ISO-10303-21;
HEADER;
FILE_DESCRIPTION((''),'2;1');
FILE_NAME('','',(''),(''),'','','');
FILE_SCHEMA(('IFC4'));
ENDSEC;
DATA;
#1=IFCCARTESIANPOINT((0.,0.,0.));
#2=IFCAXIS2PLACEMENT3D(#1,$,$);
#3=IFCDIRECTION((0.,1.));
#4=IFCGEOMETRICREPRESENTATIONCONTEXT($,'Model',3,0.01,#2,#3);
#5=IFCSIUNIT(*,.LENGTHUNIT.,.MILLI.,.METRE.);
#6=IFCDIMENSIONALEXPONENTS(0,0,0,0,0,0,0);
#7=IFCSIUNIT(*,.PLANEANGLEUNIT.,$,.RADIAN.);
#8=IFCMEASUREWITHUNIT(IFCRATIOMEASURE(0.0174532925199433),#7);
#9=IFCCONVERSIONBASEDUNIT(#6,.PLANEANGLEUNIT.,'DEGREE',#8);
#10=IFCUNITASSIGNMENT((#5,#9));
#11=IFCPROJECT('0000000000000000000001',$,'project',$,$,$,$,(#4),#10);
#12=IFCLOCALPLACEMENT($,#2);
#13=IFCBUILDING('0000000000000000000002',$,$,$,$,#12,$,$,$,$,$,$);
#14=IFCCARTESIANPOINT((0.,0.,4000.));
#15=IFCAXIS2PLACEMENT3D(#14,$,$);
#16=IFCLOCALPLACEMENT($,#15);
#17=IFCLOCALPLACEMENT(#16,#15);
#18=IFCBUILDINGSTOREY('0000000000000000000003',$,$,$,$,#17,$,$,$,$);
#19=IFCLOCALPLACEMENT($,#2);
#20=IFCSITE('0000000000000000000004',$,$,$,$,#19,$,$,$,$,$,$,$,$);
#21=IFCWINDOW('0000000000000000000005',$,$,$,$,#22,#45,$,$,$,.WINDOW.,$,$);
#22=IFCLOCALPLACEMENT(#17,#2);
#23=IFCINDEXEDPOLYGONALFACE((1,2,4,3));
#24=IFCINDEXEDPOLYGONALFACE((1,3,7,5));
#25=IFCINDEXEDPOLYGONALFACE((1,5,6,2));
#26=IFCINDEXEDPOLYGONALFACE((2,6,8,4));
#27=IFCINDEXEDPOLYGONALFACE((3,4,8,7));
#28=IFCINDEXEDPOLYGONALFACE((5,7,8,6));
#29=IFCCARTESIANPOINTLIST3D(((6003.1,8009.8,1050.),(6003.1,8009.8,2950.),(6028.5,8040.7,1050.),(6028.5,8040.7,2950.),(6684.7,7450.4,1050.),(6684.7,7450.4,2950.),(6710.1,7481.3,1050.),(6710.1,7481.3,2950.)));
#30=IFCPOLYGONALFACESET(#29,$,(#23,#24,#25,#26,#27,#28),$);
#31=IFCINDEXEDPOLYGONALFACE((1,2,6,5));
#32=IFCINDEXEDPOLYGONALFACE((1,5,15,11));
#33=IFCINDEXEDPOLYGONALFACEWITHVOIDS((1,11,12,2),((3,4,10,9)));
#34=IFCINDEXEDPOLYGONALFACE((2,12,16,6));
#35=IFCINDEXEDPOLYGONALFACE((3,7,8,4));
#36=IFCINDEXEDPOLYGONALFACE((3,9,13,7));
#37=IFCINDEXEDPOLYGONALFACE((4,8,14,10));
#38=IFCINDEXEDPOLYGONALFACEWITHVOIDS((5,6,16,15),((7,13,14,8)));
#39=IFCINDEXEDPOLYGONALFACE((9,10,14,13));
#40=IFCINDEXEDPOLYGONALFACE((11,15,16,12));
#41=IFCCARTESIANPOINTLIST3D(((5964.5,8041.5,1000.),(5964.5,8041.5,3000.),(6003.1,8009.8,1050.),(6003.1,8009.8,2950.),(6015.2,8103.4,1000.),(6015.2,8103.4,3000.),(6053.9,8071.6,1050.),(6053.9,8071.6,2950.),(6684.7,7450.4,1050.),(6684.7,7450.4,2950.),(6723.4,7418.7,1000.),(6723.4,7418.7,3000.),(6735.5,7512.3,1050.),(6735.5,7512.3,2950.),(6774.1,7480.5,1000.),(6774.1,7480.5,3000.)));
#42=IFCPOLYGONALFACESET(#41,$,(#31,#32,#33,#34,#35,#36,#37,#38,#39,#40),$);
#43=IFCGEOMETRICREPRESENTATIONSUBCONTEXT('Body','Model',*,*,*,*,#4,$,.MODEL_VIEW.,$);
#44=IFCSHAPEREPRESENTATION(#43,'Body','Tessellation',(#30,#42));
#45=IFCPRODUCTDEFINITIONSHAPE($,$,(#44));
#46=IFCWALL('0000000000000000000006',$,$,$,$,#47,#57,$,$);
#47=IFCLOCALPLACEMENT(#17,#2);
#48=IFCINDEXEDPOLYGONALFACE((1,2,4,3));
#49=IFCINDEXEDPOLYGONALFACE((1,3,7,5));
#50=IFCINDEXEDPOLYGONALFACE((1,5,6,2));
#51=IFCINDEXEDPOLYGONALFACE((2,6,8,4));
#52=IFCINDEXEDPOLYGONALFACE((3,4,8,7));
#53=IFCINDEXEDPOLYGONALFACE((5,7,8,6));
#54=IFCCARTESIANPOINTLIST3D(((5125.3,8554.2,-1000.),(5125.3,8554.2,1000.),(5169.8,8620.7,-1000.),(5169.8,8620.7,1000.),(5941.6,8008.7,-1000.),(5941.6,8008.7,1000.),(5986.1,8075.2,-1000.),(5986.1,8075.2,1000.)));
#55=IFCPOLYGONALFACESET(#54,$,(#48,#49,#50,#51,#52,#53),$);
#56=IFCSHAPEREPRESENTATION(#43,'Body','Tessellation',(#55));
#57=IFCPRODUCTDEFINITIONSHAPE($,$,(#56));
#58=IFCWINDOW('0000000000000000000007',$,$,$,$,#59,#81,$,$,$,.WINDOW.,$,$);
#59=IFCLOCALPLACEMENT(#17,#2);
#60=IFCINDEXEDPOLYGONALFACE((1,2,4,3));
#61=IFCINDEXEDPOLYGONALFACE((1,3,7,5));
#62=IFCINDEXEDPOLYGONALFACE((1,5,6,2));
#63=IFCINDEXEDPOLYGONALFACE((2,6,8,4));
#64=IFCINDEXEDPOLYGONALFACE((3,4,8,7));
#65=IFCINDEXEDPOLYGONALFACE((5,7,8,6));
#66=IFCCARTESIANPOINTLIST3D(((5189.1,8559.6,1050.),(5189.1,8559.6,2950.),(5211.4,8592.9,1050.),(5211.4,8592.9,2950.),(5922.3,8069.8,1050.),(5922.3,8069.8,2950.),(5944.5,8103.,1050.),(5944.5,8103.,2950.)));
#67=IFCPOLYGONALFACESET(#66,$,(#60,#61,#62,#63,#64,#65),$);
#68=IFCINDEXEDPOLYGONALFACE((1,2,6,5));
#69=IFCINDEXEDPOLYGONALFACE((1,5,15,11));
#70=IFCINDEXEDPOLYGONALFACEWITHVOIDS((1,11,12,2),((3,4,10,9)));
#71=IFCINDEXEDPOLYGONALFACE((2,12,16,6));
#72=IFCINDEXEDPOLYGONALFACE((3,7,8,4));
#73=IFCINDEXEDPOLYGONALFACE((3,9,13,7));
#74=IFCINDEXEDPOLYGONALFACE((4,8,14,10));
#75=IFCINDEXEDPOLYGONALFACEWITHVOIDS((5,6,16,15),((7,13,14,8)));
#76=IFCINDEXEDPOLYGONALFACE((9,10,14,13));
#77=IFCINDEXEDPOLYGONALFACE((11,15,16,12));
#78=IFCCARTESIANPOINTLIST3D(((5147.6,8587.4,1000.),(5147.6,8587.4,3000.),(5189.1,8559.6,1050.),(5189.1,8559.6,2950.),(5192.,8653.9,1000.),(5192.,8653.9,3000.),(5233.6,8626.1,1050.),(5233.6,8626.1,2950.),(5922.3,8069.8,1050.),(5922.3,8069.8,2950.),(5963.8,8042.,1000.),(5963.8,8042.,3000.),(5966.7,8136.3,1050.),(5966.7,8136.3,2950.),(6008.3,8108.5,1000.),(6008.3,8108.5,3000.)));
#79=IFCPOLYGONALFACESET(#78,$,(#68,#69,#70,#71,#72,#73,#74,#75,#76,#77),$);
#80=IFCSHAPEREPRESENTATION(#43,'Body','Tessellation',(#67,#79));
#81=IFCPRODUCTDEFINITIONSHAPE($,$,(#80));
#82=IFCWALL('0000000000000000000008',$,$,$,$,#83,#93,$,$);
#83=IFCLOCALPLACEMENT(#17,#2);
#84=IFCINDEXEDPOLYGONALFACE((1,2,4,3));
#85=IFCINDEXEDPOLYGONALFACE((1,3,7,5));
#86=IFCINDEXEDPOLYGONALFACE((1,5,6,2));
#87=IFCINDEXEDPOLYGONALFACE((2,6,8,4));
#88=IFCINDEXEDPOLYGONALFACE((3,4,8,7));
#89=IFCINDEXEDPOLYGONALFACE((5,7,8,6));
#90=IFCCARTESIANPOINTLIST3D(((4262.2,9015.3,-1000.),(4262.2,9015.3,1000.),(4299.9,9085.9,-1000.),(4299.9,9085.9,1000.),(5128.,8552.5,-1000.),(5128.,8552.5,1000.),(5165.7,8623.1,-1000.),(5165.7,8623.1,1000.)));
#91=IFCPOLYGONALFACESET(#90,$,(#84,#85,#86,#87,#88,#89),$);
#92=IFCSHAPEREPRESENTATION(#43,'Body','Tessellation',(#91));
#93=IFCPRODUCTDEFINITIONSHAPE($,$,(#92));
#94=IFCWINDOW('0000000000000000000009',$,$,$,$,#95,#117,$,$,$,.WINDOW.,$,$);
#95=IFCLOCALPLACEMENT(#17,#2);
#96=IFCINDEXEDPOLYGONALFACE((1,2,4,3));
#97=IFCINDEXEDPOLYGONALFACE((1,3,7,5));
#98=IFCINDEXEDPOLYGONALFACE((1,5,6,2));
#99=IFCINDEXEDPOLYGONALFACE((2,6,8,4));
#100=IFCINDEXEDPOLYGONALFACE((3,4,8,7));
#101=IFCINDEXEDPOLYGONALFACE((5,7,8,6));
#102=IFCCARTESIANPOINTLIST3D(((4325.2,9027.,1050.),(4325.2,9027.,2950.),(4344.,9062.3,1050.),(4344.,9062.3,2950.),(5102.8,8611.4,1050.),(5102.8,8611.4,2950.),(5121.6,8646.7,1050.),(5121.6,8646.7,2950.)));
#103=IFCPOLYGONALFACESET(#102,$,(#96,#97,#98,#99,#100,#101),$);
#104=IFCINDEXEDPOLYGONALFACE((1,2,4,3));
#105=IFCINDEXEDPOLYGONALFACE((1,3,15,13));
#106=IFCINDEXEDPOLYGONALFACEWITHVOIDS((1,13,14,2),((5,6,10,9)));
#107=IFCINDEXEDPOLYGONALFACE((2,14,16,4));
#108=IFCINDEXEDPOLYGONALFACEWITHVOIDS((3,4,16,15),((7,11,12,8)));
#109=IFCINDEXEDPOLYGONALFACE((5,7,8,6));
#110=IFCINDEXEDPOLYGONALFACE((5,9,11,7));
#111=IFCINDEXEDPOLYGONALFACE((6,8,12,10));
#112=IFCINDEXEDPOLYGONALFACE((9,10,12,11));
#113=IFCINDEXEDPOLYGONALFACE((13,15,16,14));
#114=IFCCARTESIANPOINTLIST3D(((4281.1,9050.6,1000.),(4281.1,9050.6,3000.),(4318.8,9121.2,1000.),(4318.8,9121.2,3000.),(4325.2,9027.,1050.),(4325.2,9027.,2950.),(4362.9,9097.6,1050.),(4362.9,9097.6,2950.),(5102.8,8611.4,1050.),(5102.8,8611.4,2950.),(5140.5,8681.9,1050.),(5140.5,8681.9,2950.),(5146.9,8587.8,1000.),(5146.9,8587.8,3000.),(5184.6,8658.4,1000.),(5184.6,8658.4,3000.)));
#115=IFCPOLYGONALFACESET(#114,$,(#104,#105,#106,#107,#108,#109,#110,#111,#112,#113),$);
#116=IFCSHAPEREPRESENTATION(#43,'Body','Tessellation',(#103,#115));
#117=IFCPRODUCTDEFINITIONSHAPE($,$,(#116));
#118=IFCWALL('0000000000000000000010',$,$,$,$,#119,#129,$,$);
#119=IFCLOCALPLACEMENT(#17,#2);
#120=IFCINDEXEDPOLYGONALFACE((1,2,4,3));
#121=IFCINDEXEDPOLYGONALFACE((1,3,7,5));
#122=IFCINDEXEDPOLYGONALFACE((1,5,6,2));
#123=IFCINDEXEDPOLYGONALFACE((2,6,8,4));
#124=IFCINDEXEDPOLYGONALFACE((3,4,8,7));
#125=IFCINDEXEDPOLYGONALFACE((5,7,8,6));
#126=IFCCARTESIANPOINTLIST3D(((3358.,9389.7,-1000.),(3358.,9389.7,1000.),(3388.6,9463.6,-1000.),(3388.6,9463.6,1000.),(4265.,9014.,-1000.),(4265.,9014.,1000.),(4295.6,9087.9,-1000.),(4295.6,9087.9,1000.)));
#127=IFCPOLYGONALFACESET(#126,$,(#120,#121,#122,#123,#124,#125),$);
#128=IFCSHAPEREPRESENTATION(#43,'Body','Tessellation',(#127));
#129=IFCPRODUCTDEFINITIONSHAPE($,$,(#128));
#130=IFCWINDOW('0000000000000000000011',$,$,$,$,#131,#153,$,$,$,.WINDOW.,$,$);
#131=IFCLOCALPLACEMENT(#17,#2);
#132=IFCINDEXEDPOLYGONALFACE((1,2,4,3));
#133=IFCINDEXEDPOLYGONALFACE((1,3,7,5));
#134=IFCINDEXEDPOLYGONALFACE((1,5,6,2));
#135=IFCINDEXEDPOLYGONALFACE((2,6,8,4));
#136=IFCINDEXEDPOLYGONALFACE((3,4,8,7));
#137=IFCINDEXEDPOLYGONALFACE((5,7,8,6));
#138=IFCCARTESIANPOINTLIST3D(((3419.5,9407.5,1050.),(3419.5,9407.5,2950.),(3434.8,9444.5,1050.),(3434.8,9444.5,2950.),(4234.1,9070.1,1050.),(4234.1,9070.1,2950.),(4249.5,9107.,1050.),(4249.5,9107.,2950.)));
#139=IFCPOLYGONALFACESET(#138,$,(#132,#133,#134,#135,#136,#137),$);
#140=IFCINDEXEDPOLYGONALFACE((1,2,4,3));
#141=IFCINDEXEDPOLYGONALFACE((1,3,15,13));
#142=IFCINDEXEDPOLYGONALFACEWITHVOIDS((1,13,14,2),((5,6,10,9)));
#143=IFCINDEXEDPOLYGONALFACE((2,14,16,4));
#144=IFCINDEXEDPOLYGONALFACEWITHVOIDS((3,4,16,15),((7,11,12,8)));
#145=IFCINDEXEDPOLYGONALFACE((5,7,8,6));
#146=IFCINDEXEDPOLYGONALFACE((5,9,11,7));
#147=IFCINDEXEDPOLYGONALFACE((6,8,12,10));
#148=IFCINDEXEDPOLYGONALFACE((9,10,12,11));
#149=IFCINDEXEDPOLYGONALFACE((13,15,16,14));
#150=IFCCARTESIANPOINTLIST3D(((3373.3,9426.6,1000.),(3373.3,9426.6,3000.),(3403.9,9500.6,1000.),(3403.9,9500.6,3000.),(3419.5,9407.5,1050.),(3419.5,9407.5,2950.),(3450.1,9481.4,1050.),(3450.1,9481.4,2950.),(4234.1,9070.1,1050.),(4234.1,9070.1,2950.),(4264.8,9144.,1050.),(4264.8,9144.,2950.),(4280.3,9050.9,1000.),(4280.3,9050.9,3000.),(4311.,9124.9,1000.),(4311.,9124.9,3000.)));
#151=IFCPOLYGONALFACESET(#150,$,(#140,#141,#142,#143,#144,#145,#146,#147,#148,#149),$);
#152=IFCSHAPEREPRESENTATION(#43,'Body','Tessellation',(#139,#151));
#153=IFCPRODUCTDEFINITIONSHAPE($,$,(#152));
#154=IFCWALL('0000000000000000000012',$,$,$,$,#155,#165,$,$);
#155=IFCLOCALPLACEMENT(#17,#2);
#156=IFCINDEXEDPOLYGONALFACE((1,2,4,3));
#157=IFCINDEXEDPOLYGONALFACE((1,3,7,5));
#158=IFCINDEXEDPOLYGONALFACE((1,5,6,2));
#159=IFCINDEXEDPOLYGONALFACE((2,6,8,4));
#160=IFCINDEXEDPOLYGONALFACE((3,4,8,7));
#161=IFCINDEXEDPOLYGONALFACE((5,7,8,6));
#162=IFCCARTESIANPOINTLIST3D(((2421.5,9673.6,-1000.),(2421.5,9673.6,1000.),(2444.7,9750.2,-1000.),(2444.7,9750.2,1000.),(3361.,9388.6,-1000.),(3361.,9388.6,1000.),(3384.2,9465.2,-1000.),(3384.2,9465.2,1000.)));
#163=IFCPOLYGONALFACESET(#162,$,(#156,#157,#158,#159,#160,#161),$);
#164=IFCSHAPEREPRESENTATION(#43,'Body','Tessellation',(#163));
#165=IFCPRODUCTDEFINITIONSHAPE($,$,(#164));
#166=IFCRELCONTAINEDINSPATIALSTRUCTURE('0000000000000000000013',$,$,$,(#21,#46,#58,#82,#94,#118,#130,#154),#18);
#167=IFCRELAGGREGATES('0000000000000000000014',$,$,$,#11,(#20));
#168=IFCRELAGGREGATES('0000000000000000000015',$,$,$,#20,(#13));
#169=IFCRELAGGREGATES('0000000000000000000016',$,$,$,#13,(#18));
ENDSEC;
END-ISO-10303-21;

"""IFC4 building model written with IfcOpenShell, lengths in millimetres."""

from ifc_helpers import new_model, entity, si_unit, converted_unit, direction, frame, origin, origin_2d, place, context, subcontext, project, spatial, rectangle, extrude, element, save


model = new_model("IFC4")

# Units and contexts
model_context = context("Model", 3, precision=0.01, world=origin(), true_north=direction((0.0, 1.0)))
body_context = subcontext(model_context, "Body", "Model", "MODEL_VIEW")
ifc_project = project(units=[si_unit("LENGTHUNIT", "METRE", prefix="MILLI"), converted_unit("PLANEANGLEUNIT", "DEGREE", entity("IfcRatioMeasure", 0.0174532925199433), si_unit("PLANEANGLEUNIT", "RADIAN"), dimensions=[0, 0, 0, 0, 0, 0, 0])], contexts=[model_context])

# Site, building, storey
site_placement = place(None, origin())
site = spatial("IfcSite", under=ifc_project, at=site_placement)
building_placement = place(None, origin())
building = spatial("IfcBuilding", under=site, at=building_placement)
placement = place(None, frame((0.0, 0.0, 4000.0)))
storey_placement = place(placement, frame((0.0, 0.0, 4000.0)))
storey = spatial("IfcBuildingStorey", under=building, at=storey_placement)

# Window
cartesian_point_1 = entity("IfcCartesianPoint", [-440.9, -950.0])
shared_polyline = entity("IfcPolyline", [cartesian_point_1, entity("IfcCartesianPoint", [-440.9, 950.0]), entity("IfcCartesianPoint", [-440.9, 950.0]), entity("IfcCartesianPoint", [440.9, 950.0]), entity("IfcCartesianPoint", [440.9, 950.0]), entity("IfcCartesianPoint", [440.9, -950.0]), entity("IfcCartesianPoint", [440.9, -950.0]), entity("IfcCartesianPoint", [-440.9, -950.0]), cartesian_point_1])
window_1_placement = place(storey_placement, frame((6343.9, 7730.1, 2000.0), z_axis=(0.0, 0.0, 1.0), x_axis=(-7730.104548, 6343.932824, 0.0)))
cartesian_point_2 = entity("IfcCartesianPoint", [-490.9, -1000.0])
element("IfcWindow", 1, at=window_1_placement, inside=storey, PredefinedType="WINDOW", context=body_context, shape_type="SweptSolid", body=[
    entity("IfcExtrudedAreaSolid", entity("IfcArbitraryClosedProfileDef", "AREA", None, shared_polyline), entity("IfcAxis2Placement3D", entity("IfcCartesianPoint", [0.0, 0.0, 0.0]), entity("IfcDirection", [0.0, -1.0, 0.0]), entity("IfcDirection", [1.0, 0.0, 0.0])), entity("IfcDirection", [0.0, 0.0, 1.0]), 40.0),
    entity("IfcExtrudedAreaSolid", entity("IfcArbitraryProfileDefWithVoids", "AREA", None, entity("IfcPolyline", [cartesian_point_2, entity("IfcCartesianPoint", [-490.9, 1000.0]), entity("IfcCartesianPoint", [-490.9, 1000.0]), entity("IfcCartesianPoint", [490.9, 1000.0]), entity("IfcCartesianPoint", [490.9, 1000.0]), entity("IfcCartesianPoint", [490.9, -1000.0]), entity("IfcCartesianPoint", [490.9, -1000.0]), entity("IfcCartesianPoint", [-490.9, -1000.0]), cartesian_point_2]), [shared_polyline]), entity("IfcAxis2Placement3D", entity("IfcCartesianPoint", [0.0, 0.0, 0.0]), entity("IfcDirection", [0.0, -1.0, 0.0]), entity("IfcDirection", [1.0, 0.0, 0.0])), entity("IfcDirection", [0.0, 0.0, 1.0]), 80.0),
])

# Wall
wall_1_placement = place(storey_placement, frame((5555.7, 8314.7, -1000.0), z_axis=(0.0, 0.0, 1.0), x_axis=(-8314.696026, 5555.702475, 0.0)))
element("IfcWall", 2, at=wall_1_placement, inside=storey, context=body_context, shape_type="SweptSolid", body=[
    extrude(rectangle(XDim=981.7, YDim=80.0, at=origin_2d()), origin(), (0.0, 0.0, 1.0), 2000.0),
])

# Window
window_2_placement = place(storey_placement, frame((5555.7, 8314.7, 2000.0), z_axis=(0.0, 0.0, 1.0), x_axis=(-8314.696026, 5555.702475, 0.0)))
cartesian_point_3 = entity("IfcCartesianPoint", [-490.9, -1000.0])
element("IfcWindow", 3, at=window_2_placement, inside=storey, PredefinedType="WINDOW", context=body_context, shape_type="SweptSolid", body=[
    entity("IfcExtrudedAreaSolid", entity("IfcArbitraryClosedProfileDef", "AREA", None, shared_polyline), entity("IfcAxis2Placement3D", entity("IfcCartesianPoint", [0.0, 0.0, 0.0]), entity("IfcDirection", [0.0, -1.0, 0.0]), entity("IfcDirection", [1.0, 0.0, 0.0])), entity("IfcDirection", [0.0, 0.0, 1.0]), 40.0),
    entity("IfcExtrudedAreaSolid", entity("IfcArbitraryProfileDefWithVoids", "AREA", None, entity("IfcPolyline", [cartesian_point_3, entity("IfcCartesianPoint", [-490.9, 1000.0]), entity("IfcCartesianPoint", [-490.9, 1000.0]), entity("IfcCartesianPoint", [490.9, 1000.0]), entity("IfcCartesianPoint", [490.9, 1000.0]), entity("IfcCartesianPoint", [490.9, -1000.0]), entity("IfcCartesianPoint", [490.9, -1000.0]), entity("IfcCartesianPoint", [-490.9, -1000.0]), cartesian_point_3]), [shared_polyline]), entity("IfcAxis2Placement3D", entity("IfcCartesianPoint", [0.0, 0.0, 0.0]), entity("IfcDirection", [0.0, -1.0, 0.0]), entity("IfcDirection", [1.0, 0.0, 0.0])), entity("IfcDirection", [0.0, 0.0, 1.0]), 80.0),
])

# Wall
wall_2_placement = place(storey_placement, frame((4714.0, 8819.2, -1000.0), z_axis=(0.0, 0.0, 1.0), x_axis=(-8819.212469, 4713.967695, 0.0)))
element("IfcWall", 4, at=wall_2_placement, inside=storey, context=body_context, shape_type="SweptSolid", body=[
    extrude(rectangle(XDim=981.7, YDim=80.0, at=origin_2d()), origin(), (0.0, 0.0, 1.0), 2000.0),
])

# Window
window_3_placement = place(storey_placement, frame((4714.0, 8819.2, 2000.0), z_axis=(0.0, 0.0, 1.0), x_axis=(-8819.212469, 4713.967695, 0.0)))
cartesian_point_4 = entity("IfcCartesianPoint", [-490.9, -1000.0])
element("IfcWindow", 5, at=window_3_placement, inside=storey, PredefinedType="WINDOW", context=body_context, shape_type="SweptSolid", body=[
    entity("IfcExtrudedAreaSolid", entity("IfcArbitraryClosedProfileDef", "AREA", None, shared_polyline), entity("IfcAxis2Placement3D", entity("IfcCartesianPoint", [0.0, 0.0, 0.0]), entity("IfcDirection", [0.0, -1.0, 0.0]), entity("IfcDirection", [1.0, 0.0, 0.0])), entity("IfcDirection", [0.0, 0.0, 1.0]), 40.0),
    entity("IfcExtrudedAreaSolid", entity("IfcArbitraryProfileDefWithVoids", "AREA", None, entity("IfcPolyline", [cartesian_point_4, entity("IfcCartesianPoint", [-490.9, 1000.0]), entity("IfcCartesianPoint", [-490.9, 1000.0]), entity("IfcCartesianPoint", [490.9, 1000.0]), entity("IfcCartesianPoint", [490.9, 1000.0]), entity("IfcCartesianPoint", [490.9, -1000.0]), entity("IfcCartesianPoint", [490.9, -1000.0]), entity("IfcCartesianPoint", [-490.9, -1000.0]), cartesian_point_4]), [shared_polyline]), entity("IfcAxis2Placement3D", entity("IfcCartesianPoint", [0.0, 0.0, 0.0]), entity("IfcDirection", [0.0, -1.0, 0.0]), entity("IfcDirection", [1.0, 0.0, 0.0])), entity("IfcDirection", [0.0, 0.0, 1.0]), 80.0),
])

# Wall
wall_3_placement = place(storey_placement, frame((3826.8, 9238.8, -1000.0), z_axis=(0.0, 0.0, 1.0), x_axis=(-9238.795337, 3826.834296, 0.0)))
element("IfcWall", 6, at=wall_3_placement, inside=storey, context=body_context, shape_type="SweptSolid", body=[
    extrude(rectangle(XDim=981.7, YDim=80.0, at=origin_2d()), origin(), (0.0, 0.0, 1.0), 2000.0),
])

# Window
window_4_placement = place(storey_placement, frame((3826.8, 9238.8, 2000.0), z_axis=(0.0, 0.0, 1.0), x_axis=(-9238.795337, 3826.834296, 0.0)))
cartesian_point_5 = entity("IfcCartesianPoint", [-490.9, -1000.0])
element("IfcWindow", 7, at=window_4_placement, inside=storey, PredefinedType="WINDOW", context=body_context, shape_type="SweptSolid", body=[
    entity("IfcExtrudedAreaSolid", entity("IfcArbitraryClosedProfileDef", "AREA", None, shared_polyline), entity("IfcAxis2Placement3D", entity("IfcCartesianPoint", [0.0, 0.0, 0.0]), entity("IfcDirection", [0.0, -1.0, 0.0]), entity("IfcDirection", [1.0, 0.0, 0.0])), entity("IfcDirection", [0.0, 0.0, 1.0]), 40.0),
    entity("IfcExtrudedAreaSolid", entity("IfcArbitraryProfileDefWithVoids", "AREA", None, entity("IfcPolyline", [cartesian_point_5, entity("IfcCartesianPoint", [-490.9, 1000.0]), entity("IfcCartesianPoint", [-490.9, 1000.0]), entity("IfcCartesianPoint", [490.9, 1000.0]), entity("IfcCartesianPoint", [490.9, 1000.0]), entity("IfcCartesianPoint", [490.9, -1000.0]), entity("IfcCartesianPoint", [490.9, -1000.0]), entity("IfcCartesianPoint", [-490.9, -1000.0]), cartesian_point_5]), [shared_polyline]), entity("IfcAxis2Placement3D", entity("IfcCartesianPoint", [0.0, 0.0, 0.0]), entity("IfcDirection", [0.0, -1.0, 0.0]), entity("IfcDirection", [1.0, 0.0, 0.0])), entity("IfcDirection", [0.0, 0.0, 1.0]), 80.0),
])

# Wall
wall_4_placement = place(storey_placement, frame((2902.8, 9569.4, -1000.0), z_axis=(0.0, 0.0, 1.0), x_axis=(-9569.403482, 2902.846361, 0.0)))
element("IfcWall", 8, at=wall_4_placement, inside=storey, context=body_context, shape_type="SweptSolid", body=[
    extrude(rectangle(XDim=981.7, YDim=80.0, at=origin_2d()), origin(), (0.0, 0.0, 1.0), 2000.0),
])

save(model, "model.ifc")
